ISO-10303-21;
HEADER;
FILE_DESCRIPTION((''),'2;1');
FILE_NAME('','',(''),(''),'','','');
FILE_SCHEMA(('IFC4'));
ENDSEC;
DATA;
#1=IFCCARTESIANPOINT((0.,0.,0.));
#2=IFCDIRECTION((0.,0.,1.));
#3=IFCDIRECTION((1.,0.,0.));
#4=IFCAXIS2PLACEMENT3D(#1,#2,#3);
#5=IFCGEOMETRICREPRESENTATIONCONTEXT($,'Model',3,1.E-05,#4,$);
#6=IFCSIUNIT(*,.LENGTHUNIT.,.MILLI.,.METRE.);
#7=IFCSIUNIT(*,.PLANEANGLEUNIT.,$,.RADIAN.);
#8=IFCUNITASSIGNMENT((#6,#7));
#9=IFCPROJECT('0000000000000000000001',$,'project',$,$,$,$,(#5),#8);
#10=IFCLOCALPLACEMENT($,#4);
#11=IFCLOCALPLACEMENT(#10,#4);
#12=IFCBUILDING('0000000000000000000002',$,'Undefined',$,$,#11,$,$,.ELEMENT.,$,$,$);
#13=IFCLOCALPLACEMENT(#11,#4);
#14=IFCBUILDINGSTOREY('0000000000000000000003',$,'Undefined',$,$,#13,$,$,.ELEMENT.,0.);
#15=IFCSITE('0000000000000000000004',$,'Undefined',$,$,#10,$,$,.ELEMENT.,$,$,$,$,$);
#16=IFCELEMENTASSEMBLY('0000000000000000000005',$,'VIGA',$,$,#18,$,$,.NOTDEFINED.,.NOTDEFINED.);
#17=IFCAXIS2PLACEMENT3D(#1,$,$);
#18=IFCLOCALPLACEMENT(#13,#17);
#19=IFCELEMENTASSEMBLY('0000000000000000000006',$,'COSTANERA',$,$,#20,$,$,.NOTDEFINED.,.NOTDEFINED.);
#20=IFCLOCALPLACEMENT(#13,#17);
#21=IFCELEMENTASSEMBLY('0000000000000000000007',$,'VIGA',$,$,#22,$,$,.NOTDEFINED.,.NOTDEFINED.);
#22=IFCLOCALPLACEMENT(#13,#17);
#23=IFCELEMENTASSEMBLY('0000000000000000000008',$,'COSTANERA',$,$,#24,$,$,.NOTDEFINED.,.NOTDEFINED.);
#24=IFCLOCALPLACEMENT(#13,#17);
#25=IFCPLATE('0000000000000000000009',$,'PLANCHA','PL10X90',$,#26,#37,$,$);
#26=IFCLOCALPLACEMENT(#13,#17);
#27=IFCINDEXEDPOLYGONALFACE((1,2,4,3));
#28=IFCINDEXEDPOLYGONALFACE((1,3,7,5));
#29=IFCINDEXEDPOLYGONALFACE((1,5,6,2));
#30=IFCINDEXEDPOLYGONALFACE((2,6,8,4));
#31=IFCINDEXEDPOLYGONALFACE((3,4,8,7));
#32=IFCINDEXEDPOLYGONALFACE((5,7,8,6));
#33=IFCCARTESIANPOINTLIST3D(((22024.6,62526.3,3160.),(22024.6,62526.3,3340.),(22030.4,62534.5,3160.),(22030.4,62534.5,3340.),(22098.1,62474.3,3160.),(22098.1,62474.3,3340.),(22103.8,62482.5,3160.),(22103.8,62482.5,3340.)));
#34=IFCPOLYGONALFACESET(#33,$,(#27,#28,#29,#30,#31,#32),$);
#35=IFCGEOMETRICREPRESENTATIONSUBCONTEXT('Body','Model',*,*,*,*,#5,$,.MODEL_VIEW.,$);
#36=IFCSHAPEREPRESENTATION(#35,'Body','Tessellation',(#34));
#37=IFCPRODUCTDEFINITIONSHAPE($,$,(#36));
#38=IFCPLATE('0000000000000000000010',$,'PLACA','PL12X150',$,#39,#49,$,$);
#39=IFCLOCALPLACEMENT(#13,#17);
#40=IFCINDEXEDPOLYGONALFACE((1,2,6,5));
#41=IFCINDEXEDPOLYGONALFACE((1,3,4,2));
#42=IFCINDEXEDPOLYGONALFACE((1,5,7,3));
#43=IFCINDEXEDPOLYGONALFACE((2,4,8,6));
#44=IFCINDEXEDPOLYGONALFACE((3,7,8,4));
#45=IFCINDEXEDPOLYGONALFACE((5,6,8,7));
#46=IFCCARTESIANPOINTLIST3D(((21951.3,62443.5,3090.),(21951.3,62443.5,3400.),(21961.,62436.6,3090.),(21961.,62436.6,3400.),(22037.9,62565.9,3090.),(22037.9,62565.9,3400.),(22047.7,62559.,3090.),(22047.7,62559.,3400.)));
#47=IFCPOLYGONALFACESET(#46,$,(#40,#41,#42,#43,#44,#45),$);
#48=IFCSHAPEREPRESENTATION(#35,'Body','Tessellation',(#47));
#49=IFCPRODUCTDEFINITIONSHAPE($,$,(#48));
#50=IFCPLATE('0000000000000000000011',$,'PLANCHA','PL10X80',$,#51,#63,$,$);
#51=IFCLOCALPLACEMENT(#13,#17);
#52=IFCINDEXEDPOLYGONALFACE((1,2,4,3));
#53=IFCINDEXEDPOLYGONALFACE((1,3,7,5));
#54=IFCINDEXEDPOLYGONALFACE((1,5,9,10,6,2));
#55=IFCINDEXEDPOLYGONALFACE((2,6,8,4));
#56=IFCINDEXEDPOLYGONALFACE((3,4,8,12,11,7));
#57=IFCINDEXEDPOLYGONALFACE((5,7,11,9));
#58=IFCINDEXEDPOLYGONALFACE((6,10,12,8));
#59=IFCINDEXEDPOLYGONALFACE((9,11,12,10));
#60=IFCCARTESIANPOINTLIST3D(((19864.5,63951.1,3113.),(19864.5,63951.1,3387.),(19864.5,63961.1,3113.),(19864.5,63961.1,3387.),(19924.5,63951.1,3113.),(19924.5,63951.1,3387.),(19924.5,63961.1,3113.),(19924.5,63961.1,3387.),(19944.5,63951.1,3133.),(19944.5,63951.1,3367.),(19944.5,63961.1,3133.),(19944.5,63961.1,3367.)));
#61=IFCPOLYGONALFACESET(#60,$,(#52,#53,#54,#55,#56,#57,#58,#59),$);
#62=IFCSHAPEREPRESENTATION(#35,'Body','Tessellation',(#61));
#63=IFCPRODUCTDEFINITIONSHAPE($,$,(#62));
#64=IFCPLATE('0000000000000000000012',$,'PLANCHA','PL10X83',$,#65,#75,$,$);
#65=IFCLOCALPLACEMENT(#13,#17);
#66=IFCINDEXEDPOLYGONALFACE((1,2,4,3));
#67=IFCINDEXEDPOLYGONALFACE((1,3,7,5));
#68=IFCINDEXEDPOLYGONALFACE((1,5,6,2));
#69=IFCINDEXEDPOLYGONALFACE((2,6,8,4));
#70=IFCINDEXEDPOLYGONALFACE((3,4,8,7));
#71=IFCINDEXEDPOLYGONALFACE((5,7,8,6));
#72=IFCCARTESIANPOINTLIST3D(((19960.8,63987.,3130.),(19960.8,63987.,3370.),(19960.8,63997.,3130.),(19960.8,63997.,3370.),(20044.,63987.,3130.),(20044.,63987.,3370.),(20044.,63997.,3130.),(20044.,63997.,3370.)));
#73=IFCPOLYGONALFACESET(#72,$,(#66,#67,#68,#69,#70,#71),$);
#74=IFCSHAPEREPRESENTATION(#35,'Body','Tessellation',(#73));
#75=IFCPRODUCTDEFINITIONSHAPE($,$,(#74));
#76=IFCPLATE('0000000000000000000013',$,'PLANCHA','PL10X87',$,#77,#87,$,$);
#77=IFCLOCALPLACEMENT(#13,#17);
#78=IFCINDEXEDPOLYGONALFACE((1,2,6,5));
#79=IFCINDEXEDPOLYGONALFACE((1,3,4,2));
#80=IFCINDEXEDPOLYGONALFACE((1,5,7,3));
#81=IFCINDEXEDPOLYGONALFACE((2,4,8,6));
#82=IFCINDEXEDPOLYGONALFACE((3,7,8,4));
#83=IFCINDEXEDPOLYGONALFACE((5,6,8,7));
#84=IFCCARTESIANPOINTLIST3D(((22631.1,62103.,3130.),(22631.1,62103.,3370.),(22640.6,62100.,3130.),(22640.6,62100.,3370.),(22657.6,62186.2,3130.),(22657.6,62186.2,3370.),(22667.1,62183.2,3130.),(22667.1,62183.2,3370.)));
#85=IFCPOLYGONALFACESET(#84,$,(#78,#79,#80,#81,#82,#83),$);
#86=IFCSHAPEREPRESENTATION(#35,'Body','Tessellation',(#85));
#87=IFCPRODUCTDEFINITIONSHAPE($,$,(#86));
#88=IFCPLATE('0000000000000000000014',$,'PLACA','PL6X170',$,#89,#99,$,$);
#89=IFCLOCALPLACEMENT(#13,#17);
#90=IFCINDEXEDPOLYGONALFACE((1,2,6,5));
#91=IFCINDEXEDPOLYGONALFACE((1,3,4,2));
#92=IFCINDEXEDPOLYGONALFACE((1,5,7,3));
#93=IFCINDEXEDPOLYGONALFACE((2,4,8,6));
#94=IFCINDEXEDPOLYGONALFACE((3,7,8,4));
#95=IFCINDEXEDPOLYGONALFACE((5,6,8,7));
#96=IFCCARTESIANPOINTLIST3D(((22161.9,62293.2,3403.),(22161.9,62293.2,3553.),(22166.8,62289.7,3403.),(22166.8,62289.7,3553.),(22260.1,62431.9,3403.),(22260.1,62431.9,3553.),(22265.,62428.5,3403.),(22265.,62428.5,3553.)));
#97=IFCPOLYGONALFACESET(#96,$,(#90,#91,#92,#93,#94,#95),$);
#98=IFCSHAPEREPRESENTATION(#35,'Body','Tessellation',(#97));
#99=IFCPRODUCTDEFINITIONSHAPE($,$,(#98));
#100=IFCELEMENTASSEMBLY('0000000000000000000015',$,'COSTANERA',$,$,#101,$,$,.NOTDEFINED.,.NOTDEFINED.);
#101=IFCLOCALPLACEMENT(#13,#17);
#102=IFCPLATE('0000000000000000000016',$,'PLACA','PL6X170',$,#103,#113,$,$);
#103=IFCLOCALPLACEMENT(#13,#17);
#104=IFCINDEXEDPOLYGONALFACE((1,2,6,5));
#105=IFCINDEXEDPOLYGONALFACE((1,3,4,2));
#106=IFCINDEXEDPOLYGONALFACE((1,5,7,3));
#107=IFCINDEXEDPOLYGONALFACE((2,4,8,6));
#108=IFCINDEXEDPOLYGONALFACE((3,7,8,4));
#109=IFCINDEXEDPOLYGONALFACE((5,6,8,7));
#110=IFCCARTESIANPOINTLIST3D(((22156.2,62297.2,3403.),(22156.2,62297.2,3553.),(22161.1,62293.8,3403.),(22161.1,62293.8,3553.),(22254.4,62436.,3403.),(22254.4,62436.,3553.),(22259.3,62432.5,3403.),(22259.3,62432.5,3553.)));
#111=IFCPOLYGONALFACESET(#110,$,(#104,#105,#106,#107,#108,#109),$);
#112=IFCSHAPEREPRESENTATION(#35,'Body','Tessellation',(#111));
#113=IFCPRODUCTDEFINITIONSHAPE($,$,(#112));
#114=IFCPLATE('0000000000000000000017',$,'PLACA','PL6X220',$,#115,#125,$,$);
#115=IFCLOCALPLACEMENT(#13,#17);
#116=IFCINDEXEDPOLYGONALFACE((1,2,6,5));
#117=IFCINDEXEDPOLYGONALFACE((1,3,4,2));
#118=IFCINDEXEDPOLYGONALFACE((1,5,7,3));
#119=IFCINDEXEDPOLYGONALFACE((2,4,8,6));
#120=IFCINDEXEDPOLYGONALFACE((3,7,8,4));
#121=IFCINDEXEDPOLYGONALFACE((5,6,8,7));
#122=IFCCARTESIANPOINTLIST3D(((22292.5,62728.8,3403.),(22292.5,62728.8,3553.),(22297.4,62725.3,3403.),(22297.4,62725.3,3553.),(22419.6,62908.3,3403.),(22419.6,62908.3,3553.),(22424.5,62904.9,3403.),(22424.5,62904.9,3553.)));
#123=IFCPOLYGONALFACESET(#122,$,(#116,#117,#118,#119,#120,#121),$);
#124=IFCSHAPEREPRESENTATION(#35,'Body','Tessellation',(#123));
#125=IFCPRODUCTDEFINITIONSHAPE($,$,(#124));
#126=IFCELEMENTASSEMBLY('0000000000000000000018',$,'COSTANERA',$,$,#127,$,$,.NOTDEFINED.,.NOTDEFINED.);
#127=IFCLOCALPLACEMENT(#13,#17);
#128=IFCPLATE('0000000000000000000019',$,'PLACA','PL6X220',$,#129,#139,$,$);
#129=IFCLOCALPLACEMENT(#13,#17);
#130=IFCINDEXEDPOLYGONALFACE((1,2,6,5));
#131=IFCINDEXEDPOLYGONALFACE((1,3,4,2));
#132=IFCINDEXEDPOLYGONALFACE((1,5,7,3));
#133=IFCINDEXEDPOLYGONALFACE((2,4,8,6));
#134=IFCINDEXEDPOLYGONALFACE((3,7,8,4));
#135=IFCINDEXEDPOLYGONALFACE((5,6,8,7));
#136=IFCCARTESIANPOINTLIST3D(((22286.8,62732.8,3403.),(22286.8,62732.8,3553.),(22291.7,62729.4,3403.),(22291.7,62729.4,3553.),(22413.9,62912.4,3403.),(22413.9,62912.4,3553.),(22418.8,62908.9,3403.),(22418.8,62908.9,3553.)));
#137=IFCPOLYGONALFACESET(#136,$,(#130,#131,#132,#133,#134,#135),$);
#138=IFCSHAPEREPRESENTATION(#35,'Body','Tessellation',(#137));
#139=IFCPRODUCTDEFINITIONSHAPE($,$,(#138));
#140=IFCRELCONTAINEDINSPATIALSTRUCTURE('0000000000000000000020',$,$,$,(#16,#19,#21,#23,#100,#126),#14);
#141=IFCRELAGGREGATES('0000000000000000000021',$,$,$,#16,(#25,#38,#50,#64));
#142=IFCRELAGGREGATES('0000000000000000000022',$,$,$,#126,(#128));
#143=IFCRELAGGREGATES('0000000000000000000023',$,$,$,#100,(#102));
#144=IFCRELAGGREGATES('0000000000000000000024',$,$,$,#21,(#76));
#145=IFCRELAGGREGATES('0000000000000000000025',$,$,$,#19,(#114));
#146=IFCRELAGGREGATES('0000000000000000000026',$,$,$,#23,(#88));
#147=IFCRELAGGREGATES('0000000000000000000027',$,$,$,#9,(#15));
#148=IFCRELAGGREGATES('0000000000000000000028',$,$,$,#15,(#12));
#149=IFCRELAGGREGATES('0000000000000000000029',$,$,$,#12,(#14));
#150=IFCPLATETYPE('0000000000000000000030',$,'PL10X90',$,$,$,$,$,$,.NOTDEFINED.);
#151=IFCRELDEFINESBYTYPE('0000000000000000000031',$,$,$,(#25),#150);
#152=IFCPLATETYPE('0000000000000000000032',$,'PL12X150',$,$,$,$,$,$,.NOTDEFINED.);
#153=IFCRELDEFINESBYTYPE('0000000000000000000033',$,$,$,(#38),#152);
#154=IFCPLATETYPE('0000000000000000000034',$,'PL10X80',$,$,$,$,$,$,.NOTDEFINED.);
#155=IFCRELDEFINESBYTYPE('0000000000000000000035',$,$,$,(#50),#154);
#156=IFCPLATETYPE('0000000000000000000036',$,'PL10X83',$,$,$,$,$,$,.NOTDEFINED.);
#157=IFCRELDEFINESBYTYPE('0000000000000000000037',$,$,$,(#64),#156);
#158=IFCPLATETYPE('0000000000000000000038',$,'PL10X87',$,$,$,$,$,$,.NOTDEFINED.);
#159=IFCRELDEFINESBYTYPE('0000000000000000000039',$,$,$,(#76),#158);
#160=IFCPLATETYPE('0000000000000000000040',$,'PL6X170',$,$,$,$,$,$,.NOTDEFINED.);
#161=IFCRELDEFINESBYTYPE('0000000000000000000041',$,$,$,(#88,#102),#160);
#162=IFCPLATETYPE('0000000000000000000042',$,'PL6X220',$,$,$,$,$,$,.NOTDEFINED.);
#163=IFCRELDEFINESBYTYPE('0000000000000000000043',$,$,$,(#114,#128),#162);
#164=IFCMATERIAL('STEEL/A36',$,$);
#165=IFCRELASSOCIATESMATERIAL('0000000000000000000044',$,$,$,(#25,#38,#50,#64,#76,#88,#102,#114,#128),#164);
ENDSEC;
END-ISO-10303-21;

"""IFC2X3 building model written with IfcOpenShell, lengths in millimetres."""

from ifc_helpers import new_model, si_unit, frame, origin_with_axes, origin_2d_with_axis, place, context, subcontext, project, spatial, polyline, rectangle, outline, extrude, material, type_object, element, aggregate, save


model = new_model("IFC2X3")

# Units and contexts
model_context = context("Model", 3, precision=1e-05, world=origin_with_axes())
body_context = subcontext(model_context, "Body", "Model", "MODEL_VIEW")
ifc_project = project(units=[si_unit("LENGTHUNIT", "METRE", prefix="MILLI"), si_unit("PLANEANGLEUNIT", "RADIAN")], contexts=[model_context])

# Site, building, storey
site_placement = place(None, origin_with_axes())
site = spatial("IfcSite", under=ifc_project, at=site_placement, Name="Undefined", CompositionType="ELEMENT")
building_placement = place(site_placement, origin_with_axes())
building = spatial("IfcBuilding", under=site, at=building_placement, Name="Undefined", CompositionType="ELEMENT")
storey_placement = place(building_placement, origin_with_axes())
storey = spatial("IfcBuildingStorey", under=building, at=storey_placement, Name="Undefined", CompositionType="ELEMENT", Elevation=0.0)

# Element assembly
assembly_1_placement = place(storey_placement, origin_with_axes())
assembly_1 = element("IfcElementAssembly", 1, at=assembly_1_placement, inside=storey, Name="VIGA", AssemblyPlace="NOTDEFINED", PredefinedType="NOTDEFINED")
ifc_material_1 = material(Name="STEEL/A36")

# Element assembly
assembly_2_placement = place(storey_placement, origin_with_axes())
assembly_2 = element("IfcElementAssembly", 2, at=assembly_2_placement, inside=storey, Name="COSTANERA", AssemblyPlace="NOTDEFINED", PredefinedType="NOTDEFINED")

# Element assembly
assembly_3_placement = place(storey_placement, origin_with_axes())
assembly_3 = element("IfcElementAssembly", 3, at=assembly_3_placement, inside=storey, Name="VIGA", AssemblyPlace="NOTDEFINED", PredefinedType="NOTDEFINED")

# Element assembly
assembly_4_placement = place(storey_placement, origin_with_axes())
assembly_4 = element("IfcElementAssembly", 4, at=assembly_4_placement, inside=storey, Name="COSTANERA", AssemblyPlace="NOTDEFINED", PredefinedType="NOTDEFINED")

# Plates
plate_type_1 = type_object("IfcPlateType", Name="PL10X90", PredefinedType="NOTDEFINED")
plate_1_placement = place(assembly_1_placement, frame((22027.5, 62530.4, 3340.0), z_axis=(-0.577701, -0.816249, 0.0), x_axis=(0.0, 0.0, -1.0)))
plate_1 = element("IfcPlate", 5, at=plate_1_placement, type_object=plate_type_1, material=ifc_material_1, Name="PLANCHA", Description="PL10X90", context=body_context, shape_type="SweptSolid", body=[
    extrude(outline(polyline([(0.0, 0.0), (180.0, 0.0), (180.0, 90.0), (0.0, 90.0), (0.0, 0.0)])), frame((0.0, 0.0, -5.0), z_axis=(0.0, 0.0, 1.0), x_axis=(1.0, 0.0, 0.0)), (0.0, 0.0, 1.0), 10.0),
])
plate_type_2 = type_object("IfcPlateType", Name="PL12X150", PredefinedType="NOTDEFINED")
plate_2_placement = place(assembly_1_placement, frame((21999.5, 62501.2, 3090.0), z_axis=(0.577701, 0.816249, 0.0), x_axis=(0.0, 0.0, 1.0)))
plate_2 = element("IfcPlate", 6, at=plate_2_placement, type_object=plate_type_2, material=ifc_material_1, Name="PLACA", Description="PL12X150", context=body_context, shape_type="SweptSolid", body=[
    extrude(rectangle(XDim=12.0, YDim=150.0, at=origin_2d_with_axis()), frame((310.0, 0.0, 0.0), z_axis=(-1.0, 0.0, 0.0), x_axis=(0.0, -1.0, 0.0)), (0.0, 0.0, 1.0), 310.0),
])
plate_type_3 = type_object("IfcPlateType", Name="PL10X80", PredefinedType="NOTDEFINED")
plate_3_placement = place(assembly_1_placement, frame((19944.5, 63956.1, 3113.0), z_axis=(0.0, 1.0, 0.0), x_axis=(-1.0, 0.0, 0.0)))
plate_3 = element("IfcPlate", 7, at=plate_3_placement, type_object=plate_type_3, material=ifc_material_1, Name="PLANCHA", Description="PL10X80", context=body_context, shape_type="SweptSolid", body=[
    extrude(outline(polyline([(0.0, 20.0), (20.0, 0.0), (80.0, 0.0), (80.0, 274.0), (20.0, 274.0), (0.0, 254.0), (0.0, 20.0)])), frame((0.0, 0.0, -5.0), z_axis=(0.0, 0.0, 1.0), x_axis=(1.0, 0.0, 0.0)), (0.0, 0.0, 1.0), 10.0),
])
plate_type_4 = type_object("IfcPlateType", Name="PL10X83", PredefinedType="NOTDEFINED")
plate_4_placement = place(assembly_1_placement, frame((19960.8, 63992.0, 3370.0), z_axis=(0.0, -1.0, 0.0), x_axis=(0.0, 0.0, -1.0)))
plate_4 = element("IfcPlate", 8, at=plate_4_placement, type_object=plate_type_4, material=ifc_material_1, Name="PLANCHA", Description="PL10X83", context=body_context, shape_type="SweptSolid", body=[
    extrude(outline(polyline([(0.0, 0.0), (240.0, 0.0), (240.0, 83.2), (0.0, 83.2), (0.0, 0.0)])), frame((0.0, 0.0, -5.0), z_axis=(0.0, 0.0, 1.0), x_axis=(1.0, 0.0, 0.0)), (0.0, 0.0, 1.0), 10.0),
])
aggregate(assembly_1, [plate_1, plate_2, plate_3, plate_4])
plate_type_5 = type_object("IfcPlateType", Name="PL10X87", PredefinedType="NOTDEFINED")
plate_5_placement = place(assembly_3_placement, frame((22635.9, 62101.5, 3370.0), z_axis=(0.952956, -0.30311, 0.0), x_axis=(0.0, 0.0, -1.0)))
plate_5 = element("IfcPlate", 9, at=plate_5_placement, type_object=plate_type_5, material=ifc_material_1, Name="PLANCHA", Description="PL10X87", context=body_context, shape_type="SweptSolid", body=[
    extrude(outline(polyline([(0.0, 0.0), (240.0, 0.0), (240.0, 87.3), (0.0, 87.3), (0.0, 0.0)])), frame((0.0, 0.0, -5.0), z_axis=(0.0, 0.0, 1.0), x_axis=(1.0, 0.0, 0.0)), (0.0, 0.0, 1.0), 10.0),
])
plate_type_6 = type_object("IfcPlateType", Name="PL6X170", PredefinedType="NOTDEFINED")
plate_6_placement = place(assembly_4_placement, frame((22213.4, 62360.8, 3403.0), z_axis=(0.816249, -0.577701, 0.0), x_axis=(0.0, 0.0, 1.0)))
plate_6 = element("IfcPlate", 10, at=plate_6_placement, type_object=plate_type_6, material=ifc_material_1, Name="PLACA", Description="PL6X170", context=body_context, shape_type="SweptSolid", body=[
    extrude(outline(polyline([(0.0, -85.0), (0.0, 85.0), (150.0, 85.0), (150.0, -85.0), (0.0, -85.0)])), frame((0.0, 0.0, -3.0), z_axis=(0.0, 0.0, 1.0), x_axis=(1.0, 0.0, 0.0)), (0.0, 0.0, 1.0), 6.0),
])

# Element assembly, plate
assembly_5_placement = place(storey_placement, origin_with_axes())
assembly_5 = element("IfcElementAssembly", 11, at=assembly_5_placement, inside=storey, Name="COSTANERA", AssemblyPlace="NOTDEFINED", PredefinedType="NOTDEFINED")
plate_7_placement = place(assembly_5_placement, frame((22207.7, 62364.9, 3403.0), z_axis=(0.816249, -0.577701, 0.0), x_axis=(0.0, 0.0, 1.0)))
plate_7 = element("IfcPlate", 12, at=plate_7_placement, type_object=plate_type_6, material=ifc_material_1, Name="PLACA", Description="PL6X170", context=body_context, shape_type="SweptSolid", body=[
    extrude(outline(polyline([(0.0, -85.0), (0.0, 85.0), (150.0, 85.0), (150.0, -85.0), (0.0, -85.0)])), frame((0.0, 0.0, -3.0), z_axis=(0.0, 0.0, 1.0), x_axis=(1.0, 0.0, 0.0)), (0.0, 0.0, 1.0), 6.0),
])

# Plate
plate_type_7 = type_object("IfcPlateType", Name="PL6X220", PredefinedType="NOTDEFINED")
plate_8_placement = place(assembly_2_placement, frame((22358.5, 62816.8, 3403.0), z_axis=(0.816249, -0.577701, 0.0), x_axis=(0.0, 0.0, 1.0)))
plate_8 = element("IfcPlate", 13, at=plate_8_placement, type_object=plate_type_7, material=ifc_material_1, Name="PLACA", Description="PL6X220", context=body_context, shape_type="SweptSolid", body=[
    extrude(outline(polyline([(0.0, -110.0), (0.0, 110.0), (150.0, 110.0), (150.0, -110.0), (0.0, -110.0)])), frame((0.0, 0.0, -3.0), z_axis=(0.0, 0.0, 1.0), x_axis=(1.0, 0.0, 0.0)), (0.0, 0.0, 1.0), 6.0),
])

# Element assembly, plate
assembly_6_placement = place(storey_placement, origin_with_axes())
assembly_6 = element("IfcElementAssembly", 14, at=assembly_6_placement, inside=storey, Name="COSTANERA", AssemblyPlace="NOTDEFINED", PredefinedType="NOTDEFINED")
plate_9_placement = place(assembly_6_placement, frame((22352.8, 62820.9, 3403.0), z_axis=(0.816249, -0.577701, 0.0), x_axis=(0.0, 0.0, 1.0)))
plate_9 = element("IfcPlate", 15, at=plate_9_placement, type_object=plate_type_7, material=ifc_material_1, Name="PLACA", Description="PL6X220", context=body_context, shape_type="SweptSolid", body=[
    extrude(outline(polyline([(0.0, -110.0), (0.0, 110.0), (150.0, 110.0), (150.0, -110.0), (0.0, -110.0)])), frame((0.0, 0.0, -3.0), z_axis=(0.0, 0.0, 1.0), x_axis=(1.0, 0.0, 0.0)), (0.0, 0.0, 1.0), 6.0),
])
aggregate(assembly_6, [plate_9])

aggregate(assembly_5, [plate_7])

aggregate(assembly_3, [plate_5])
aggregate(assembly_2, [plate_8])
aggregate(assembly_4, [plate_6])

save(model, "model.ifc")
